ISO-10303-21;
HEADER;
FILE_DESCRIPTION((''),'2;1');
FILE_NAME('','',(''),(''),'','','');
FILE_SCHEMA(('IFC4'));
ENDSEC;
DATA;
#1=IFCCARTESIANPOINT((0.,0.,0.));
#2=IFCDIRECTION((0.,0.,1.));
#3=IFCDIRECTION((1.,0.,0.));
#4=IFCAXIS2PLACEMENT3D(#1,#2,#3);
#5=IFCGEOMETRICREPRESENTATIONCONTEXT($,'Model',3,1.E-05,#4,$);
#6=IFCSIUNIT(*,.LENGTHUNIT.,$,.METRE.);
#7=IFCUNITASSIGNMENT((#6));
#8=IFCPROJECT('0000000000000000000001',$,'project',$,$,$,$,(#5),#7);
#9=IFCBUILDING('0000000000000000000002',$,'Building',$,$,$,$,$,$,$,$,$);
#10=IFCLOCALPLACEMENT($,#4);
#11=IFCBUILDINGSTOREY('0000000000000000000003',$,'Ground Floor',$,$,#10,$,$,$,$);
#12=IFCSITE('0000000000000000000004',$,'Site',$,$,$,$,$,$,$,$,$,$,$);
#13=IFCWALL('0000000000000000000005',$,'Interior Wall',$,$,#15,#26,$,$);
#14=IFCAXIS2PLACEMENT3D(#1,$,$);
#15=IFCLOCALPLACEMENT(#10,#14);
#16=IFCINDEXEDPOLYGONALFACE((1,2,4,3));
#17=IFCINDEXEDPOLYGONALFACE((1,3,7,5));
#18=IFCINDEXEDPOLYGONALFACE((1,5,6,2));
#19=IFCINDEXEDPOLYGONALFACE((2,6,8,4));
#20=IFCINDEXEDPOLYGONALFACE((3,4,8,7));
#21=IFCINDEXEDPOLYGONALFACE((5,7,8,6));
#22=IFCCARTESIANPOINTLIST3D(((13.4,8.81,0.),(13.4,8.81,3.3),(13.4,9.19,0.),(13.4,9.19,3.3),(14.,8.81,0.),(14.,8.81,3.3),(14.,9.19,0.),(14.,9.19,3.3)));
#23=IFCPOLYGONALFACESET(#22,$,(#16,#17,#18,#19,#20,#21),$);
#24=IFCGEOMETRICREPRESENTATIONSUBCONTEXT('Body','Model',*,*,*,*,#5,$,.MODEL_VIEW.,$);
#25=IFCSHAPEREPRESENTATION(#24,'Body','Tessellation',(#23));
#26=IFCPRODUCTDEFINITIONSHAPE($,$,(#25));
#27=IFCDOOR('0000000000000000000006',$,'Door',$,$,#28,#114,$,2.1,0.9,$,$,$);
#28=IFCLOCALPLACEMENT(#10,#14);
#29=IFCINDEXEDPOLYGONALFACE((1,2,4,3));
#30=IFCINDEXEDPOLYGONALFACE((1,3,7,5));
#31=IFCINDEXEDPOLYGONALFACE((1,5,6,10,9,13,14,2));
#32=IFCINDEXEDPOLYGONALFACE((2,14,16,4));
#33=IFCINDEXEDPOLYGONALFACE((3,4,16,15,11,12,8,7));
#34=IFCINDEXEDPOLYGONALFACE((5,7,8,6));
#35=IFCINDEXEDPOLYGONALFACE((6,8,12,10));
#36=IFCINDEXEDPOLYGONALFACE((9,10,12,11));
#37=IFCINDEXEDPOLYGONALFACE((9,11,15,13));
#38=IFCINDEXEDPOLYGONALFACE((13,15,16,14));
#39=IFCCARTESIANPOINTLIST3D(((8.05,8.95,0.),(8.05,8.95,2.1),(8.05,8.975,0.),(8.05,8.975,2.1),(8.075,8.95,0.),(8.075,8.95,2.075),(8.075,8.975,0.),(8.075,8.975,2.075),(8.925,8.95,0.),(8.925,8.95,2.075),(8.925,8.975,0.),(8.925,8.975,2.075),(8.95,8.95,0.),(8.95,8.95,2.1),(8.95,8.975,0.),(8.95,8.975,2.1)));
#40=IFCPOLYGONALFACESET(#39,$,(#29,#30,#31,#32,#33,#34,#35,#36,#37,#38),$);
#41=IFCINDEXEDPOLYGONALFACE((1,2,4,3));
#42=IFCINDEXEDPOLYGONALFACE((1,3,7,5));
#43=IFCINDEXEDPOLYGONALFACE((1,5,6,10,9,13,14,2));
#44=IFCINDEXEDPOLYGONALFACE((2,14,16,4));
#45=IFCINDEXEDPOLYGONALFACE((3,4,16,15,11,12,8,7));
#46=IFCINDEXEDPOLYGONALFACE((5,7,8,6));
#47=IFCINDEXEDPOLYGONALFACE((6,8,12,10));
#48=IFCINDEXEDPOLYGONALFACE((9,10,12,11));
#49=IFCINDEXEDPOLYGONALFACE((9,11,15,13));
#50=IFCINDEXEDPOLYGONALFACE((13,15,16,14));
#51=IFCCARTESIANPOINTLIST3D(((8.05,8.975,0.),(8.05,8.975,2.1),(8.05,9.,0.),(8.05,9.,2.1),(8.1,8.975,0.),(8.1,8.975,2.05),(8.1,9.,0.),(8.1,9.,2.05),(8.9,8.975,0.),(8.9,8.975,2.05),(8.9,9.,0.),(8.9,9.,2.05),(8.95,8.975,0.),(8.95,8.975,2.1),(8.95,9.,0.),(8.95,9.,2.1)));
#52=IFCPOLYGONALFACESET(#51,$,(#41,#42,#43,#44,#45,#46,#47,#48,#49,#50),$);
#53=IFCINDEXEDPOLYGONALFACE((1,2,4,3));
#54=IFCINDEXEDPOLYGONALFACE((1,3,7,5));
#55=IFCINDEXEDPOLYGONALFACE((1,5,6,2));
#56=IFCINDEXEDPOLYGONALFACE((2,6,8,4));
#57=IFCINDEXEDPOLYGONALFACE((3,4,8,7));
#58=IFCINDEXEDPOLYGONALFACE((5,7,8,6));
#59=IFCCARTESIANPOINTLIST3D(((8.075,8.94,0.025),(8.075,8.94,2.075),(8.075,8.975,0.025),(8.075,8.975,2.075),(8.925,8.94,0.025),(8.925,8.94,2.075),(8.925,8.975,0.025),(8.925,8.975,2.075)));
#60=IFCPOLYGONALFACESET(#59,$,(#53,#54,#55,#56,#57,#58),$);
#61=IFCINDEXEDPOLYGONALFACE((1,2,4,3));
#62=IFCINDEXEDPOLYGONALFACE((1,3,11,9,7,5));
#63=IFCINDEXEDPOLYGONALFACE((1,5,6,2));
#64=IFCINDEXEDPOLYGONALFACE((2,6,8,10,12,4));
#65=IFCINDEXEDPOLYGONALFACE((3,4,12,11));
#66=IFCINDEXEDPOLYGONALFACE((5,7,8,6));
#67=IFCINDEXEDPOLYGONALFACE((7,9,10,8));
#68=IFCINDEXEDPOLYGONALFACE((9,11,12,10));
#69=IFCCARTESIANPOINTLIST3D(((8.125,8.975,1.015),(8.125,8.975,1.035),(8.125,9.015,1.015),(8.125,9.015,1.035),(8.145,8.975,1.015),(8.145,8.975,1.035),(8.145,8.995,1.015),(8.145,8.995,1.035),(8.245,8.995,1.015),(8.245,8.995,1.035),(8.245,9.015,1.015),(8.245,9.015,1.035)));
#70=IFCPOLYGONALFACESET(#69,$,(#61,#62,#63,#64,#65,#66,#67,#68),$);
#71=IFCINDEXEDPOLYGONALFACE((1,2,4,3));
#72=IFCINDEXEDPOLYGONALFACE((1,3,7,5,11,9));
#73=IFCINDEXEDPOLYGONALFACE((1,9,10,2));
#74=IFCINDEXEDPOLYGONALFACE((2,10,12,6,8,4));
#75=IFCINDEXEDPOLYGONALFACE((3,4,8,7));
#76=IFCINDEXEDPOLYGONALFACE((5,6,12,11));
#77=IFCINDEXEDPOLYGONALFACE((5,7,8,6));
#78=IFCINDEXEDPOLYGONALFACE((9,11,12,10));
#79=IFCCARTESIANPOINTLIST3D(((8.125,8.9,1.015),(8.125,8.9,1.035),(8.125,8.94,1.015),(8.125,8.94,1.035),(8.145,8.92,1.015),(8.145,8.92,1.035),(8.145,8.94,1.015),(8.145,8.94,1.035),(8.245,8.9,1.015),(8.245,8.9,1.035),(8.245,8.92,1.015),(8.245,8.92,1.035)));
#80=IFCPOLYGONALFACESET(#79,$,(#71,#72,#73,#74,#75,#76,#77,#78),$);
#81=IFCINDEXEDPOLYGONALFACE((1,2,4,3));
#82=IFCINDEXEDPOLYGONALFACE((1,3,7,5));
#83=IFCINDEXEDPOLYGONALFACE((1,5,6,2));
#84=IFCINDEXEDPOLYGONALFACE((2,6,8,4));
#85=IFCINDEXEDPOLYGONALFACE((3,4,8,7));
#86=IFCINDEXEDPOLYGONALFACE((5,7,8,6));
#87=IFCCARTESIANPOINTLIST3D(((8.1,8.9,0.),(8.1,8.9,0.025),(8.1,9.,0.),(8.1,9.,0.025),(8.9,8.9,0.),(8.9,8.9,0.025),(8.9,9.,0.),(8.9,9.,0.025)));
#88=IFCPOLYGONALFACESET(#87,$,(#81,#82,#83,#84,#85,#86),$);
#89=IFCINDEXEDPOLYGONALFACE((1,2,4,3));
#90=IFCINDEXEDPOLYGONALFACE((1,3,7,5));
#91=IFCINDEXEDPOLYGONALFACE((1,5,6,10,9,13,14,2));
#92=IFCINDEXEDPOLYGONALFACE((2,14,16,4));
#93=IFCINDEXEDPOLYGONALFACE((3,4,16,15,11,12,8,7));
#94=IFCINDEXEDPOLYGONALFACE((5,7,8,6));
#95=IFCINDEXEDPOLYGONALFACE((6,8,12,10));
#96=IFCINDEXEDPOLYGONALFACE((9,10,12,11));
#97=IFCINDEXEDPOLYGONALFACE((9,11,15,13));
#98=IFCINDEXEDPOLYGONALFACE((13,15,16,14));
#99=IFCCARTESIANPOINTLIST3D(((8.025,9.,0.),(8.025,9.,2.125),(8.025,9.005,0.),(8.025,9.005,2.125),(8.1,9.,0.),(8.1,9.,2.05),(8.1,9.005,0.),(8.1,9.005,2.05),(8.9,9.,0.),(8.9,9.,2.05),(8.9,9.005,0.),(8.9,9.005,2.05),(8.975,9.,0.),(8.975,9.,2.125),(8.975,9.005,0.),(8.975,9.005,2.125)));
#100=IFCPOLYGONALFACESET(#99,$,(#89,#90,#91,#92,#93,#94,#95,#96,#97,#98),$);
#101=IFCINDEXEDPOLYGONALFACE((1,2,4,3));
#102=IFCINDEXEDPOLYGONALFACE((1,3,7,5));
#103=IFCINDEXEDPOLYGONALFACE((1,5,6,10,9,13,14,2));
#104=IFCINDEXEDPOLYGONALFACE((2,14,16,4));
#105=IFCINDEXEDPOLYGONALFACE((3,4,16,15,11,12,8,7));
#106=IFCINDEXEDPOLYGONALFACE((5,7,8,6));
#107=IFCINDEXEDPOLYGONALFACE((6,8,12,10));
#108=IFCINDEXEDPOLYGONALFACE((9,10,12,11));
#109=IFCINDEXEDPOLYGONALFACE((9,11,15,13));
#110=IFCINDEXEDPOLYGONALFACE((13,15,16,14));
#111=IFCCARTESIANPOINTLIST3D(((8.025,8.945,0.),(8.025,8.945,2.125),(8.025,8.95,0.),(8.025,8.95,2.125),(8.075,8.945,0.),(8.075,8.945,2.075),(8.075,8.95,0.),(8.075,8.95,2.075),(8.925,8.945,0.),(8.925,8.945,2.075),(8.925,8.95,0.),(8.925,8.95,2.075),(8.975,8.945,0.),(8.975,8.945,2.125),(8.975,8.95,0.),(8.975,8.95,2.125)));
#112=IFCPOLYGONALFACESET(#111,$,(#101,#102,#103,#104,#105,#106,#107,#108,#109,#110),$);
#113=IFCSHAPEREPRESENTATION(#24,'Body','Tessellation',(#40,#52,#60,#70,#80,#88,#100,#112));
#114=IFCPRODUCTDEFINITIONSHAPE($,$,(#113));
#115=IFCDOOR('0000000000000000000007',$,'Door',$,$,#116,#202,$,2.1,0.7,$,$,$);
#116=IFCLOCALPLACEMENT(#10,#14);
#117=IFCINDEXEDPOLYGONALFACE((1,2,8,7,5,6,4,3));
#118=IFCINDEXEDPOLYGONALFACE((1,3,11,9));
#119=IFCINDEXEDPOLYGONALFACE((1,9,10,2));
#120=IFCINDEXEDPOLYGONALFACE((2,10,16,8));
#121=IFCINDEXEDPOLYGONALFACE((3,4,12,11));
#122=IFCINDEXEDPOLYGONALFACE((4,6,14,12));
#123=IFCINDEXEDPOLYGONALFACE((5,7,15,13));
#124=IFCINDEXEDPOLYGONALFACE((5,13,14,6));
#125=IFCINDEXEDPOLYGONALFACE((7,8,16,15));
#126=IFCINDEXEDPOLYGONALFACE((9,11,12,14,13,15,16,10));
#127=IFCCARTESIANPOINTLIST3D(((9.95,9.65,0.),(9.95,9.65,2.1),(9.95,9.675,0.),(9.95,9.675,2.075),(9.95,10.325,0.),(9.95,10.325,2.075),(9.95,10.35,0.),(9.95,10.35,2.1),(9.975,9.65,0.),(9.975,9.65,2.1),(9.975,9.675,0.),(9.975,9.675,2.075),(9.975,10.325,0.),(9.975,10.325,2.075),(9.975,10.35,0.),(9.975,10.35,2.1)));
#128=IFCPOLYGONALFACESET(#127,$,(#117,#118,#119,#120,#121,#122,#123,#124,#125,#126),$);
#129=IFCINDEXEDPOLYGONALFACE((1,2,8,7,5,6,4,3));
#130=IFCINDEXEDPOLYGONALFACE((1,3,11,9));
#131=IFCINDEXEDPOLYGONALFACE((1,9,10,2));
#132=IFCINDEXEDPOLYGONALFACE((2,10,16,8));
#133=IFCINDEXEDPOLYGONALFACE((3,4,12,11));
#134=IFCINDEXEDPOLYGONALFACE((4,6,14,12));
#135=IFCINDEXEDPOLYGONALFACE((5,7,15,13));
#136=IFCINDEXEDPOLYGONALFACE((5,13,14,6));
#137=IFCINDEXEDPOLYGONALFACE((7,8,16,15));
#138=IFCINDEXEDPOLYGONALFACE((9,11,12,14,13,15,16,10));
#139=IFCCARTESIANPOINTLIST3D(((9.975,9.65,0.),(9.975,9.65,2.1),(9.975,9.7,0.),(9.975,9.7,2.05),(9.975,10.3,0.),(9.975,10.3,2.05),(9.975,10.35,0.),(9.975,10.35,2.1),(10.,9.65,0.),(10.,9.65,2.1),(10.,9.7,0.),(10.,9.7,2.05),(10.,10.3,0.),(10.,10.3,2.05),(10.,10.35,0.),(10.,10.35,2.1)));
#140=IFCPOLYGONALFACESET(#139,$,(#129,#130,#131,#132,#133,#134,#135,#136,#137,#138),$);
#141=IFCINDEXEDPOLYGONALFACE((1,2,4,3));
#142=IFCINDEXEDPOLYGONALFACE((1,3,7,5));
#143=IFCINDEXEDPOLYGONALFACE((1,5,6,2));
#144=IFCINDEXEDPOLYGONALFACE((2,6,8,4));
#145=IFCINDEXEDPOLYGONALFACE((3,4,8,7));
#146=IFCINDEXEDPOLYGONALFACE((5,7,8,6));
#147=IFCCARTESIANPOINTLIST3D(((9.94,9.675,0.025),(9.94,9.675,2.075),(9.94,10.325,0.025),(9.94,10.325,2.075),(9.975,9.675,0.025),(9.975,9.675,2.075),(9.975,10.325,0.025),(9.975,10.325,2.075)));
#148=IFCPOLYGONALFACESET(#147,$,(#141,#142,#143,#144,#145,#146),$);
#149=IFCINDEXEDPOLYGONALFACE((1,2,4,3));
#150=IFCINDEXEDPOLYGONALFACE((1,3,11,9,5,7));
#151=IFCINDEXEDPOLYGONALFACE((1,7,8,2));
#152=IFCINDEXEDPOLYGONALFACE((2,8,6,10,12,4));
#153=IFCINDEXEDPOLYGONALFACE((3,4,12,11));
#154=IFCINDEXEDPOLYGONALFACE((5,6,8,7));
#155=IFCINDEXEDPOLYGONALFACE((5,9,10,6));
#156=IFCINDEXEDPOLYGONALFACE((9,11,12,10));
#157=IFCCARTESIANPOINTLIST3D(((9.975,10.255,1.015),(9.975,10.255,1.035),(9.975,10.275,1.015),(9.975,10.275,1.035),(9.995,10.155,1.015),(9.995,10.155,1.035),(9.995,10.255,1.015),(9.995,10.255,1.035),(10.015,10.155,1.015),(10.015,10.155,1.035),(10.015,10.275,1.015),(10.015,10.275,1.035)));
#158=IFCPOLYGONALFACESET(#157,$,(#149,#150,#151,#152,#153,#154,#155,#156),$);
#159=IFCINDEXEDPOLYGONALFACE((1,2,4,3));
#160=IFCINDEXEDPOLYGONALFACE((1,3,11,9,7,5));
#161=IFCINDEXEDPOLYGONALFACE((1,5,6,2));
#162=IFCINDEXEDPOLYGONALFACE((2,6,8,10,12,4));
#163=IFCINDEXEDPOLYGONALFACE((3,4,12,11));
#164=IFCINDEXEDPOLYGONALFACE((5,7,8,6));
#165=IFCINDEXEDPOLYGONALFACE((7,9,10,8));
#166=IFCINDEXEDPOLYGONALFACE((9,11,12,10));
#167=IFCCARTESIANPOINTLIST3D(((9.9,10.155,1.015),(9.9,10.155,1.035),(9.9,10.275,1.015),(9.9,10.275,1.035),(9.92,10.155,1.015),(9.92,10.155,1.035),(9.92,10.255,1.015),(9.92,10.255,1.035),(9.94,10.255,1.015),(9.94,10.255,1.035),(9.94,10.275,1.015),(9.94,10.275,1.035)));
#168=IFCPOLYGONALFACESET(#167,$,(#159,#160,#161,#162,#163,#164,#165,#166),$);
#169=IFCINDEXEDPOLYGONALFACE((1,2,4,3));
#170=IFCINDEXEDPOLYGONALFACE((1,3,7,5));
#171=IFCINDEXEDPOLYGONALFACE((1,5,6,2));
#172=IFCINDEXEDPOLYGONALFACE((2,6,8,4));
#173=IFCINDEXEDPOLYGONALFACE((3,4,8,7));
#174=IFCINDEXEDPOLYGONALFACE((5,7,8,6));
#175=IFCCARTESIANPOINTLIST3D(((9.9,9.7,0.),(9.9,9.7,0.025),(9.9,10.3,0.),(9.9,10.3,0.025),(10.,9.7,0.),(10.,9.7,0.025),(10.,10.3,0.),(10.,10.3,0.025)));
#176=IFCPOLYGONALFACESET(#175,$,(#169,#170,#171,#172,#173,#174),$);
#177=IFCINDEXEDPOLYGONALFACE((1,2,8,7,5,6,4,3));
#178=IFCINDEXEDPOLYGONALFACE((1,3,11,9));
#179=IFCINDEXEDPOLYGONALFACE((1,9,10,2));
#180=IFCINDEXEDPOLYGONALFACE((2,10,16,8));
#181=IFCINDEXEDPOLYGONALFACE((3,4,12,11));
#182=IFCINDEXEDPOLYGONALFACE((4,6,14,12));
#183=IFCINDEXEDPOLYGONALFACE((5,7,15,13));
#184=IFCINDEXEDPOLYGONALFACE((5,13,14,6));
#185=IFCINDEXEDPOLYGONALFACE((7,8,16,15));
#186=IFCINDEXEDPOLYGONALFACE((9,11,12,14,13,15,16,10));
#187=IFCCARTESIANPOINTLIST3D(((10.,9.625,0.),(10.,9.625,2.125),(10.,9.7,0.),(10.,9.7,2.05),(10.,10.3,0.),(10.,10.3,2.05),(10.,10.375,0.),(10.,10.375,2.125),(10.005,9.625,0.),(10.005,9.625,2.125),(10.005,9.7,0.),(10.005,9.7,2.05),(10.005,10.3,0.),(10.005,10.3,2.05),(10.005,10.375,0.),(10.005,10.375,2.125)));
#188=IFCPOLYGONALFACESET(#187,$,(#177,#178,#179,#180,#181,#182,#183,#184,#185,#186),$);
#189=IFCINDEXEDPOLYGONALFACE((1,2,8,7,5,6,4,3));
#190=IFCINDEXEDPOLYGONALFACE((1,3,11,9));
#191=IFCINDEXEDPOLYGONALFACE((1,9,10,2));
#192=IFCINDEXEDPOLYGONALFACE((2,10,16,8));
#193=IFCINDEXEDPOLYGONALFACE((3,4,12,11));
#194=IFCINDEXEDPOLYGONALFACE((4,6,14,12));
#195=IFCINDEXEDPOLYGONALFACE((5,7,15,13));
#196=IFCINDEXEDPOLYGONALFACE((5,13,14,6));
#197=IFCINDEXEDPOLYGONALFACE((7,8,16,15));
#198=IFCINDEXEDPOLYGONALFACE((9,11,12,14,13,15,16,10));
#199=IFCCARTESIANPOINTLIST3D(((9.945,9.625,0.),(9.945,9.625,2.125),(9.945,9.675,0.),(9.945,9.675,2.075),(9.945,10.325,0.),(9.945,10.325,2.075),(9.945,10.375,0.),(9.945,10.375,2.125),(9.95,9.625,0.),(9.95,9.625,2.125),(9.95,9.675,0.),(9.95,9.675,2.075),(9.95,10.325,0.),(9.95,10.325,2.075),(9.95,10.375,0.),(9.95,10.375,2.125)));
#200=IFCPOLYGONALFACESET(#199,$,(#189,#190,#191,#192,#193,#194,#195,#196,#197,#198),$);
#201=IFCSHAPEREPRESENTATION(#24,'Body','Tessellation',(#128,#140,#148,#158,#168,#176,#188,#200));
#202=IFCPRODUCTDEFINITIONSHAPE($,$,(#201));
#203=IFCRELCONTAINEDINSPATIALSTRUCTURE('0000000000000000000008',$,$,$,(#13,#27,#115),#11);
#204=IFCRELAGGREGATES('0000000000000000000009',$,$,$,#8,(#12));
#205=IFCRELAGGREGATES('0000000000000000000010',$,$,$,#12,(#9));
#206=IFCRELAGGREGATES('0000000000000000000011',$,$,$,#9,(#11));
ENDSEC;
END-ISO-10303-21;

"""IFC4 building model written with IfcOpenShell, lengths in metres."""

from ifc_helpers import new_model, si_unit, frame, origin_with_axes, place, context, subcontext, project, spatial, line, indexed_curve, outline, extrude, element, save


model = new_model("IFC4")

# Units and contexts
model_context = context("Model", 3, precision=1e-05, world=origin_with_axes())
body_context = subcontext(model_context, "Body", "Model", "MODEL_VIEW")
ifc_project = project(units=[si_unit("LENGTHUNIT", "METRE")], contexts=[model_context])

# Site, building, storey
site = spatial("IfcSite", under=ifc_project, Name="Site")
building = spatial("IfcBuilding", under=site, Name="Building")
storey_placement = place(None, origin_with_axes())
storey = spatial("IfcBuildingStorey", under=building, at=storey_placement, Name="Ground Floor")

# Wall
for number, where, z_axis, x_axis, name in (
    (1, (13.4, 9.0, 0.0), (0.0, 0.0, 1.0), (1.0, 0.0, 0.0), "Interior Wall"),
):
    element("IfcWall", number, at=place(storey_placement, frame(where, z_axis=z_axis, x_axis=x_axis)), inside=storey, Name=name, context=body_context, shape_type="SweptSolid", body=[
        extrude(outline(indexed_curve([(0.0, 0.0), (0.0, 0.38), (0.6, 0.38), (0.6, 0.0), (0.0, 0.0)], self_intersect=False)), frame((0.0, -0.19, 0.0), z_axis=(0.0, 0.0, 1.0), x_axis=(1.0, 0.0, 0.0)), (0.0, 0.0, 1.0), 3.3),
    ])

# Doors
door_1_placement = place(storey_placement, frame((8.95, 9.0, 0.0), z_axis=(0.0, 0.0, 1.0), x_axis=(-1.0, 0.0, 0.0)))
element("IfcDoor", 2, at=door_1_placement, inside=storey, Name="Door", OverallHeight=2.1, OverallWidth=0.9, context=body_context, shape_type="SweptSolid", body=[
    extrude(outline(indexed_curve([(0.0, 0.0), (0.0, 2.1), (0.9, 2.1), (0.9, 0.0), (0.875, 0.0), (0.875, 2.075), (0.025, 2.075), (0.025, 0.0)], segments=[line(1, 2, 3, 4, 5, 6, 7, 8, 1)])), frame((0.0, 0.025, 0.0), z_axis=(0.0, -1.0, 0.0), x_axis=(1.0, 0.0, 0.0)), (0.0, 0.0, -1.0), 0.025),
    extrude(outline(indexed_curve([(0.0, 0.0), (0.0, 2.1), (0.9, 2.1), (0.9, 0.0), (0.85, 0.0), (0.85, 2.05), (0.05, 2.05), (0.05, 0.0)], segments=[line(1, 2, 3, 4, 5, 6, 7, 8, 1)])), frame((0.0, 0.0, 0.0), z_axis=(0.0, -1.0, 0.0), x_axis=(1.0, 0.0, 0.0)), (0.0, 0.0, -1.0), 0.025),
    extrude(outline(indexed_curve([(0.0, 0.0), (0.85, 0.0), (0.85, 0.035), (0.0, 0.035)], segments=[line(1, 2, 3, 4, 1)])), frame((0.025, 0.025, 0.025), z_axis=(0.0, 0.0, 1.0), x_axis=(1.0, 0.0, 0.0)), (0.0, 0.0, 1.0), 2.05),
    extrude(outline(indexed_curve([(0.0, 0.0), (0.0, -0.04), (-0.12, -0.04), (-0.12, -0.02), (-0.02, -0.02), (-0.02, 0.0)], segments=[line(1, 2, 3, 4, 5, 6, 1)])), frame((0.825, 0.025, 1.015), z_axis=(0.0, 0.0, 1.0), x_axis=(1.0, 0.0, 0.0)), (0.0, 0.0, 1.0), 0.02),
    extrude(outline(indexed_curve([(0.0, 0.0), (0.0, 0.04), (-0.12, 0.04), (-0.12, 0.02), (-0.02, 0.02), (-0.02, 0.0)], segments=[line(1, 2, 3, 4, 5, 6, 1)])), frame((0.825, 0.06, 1.015), z_axis=(0.0, 0.0, 1.0), x_axis=(1.0, 0.0, 0.0)), (0.0, 0.0, 1.0), 0.02),
    extrude(outline(indexed_curve([(0.0, 0.0), (0.8, 0.0), (0.8, 0.1), (0.0, 0.1)], segments=[line(1, 2, 3, 4, 1)])), frame((0.05, 0.0, 0.0), z_axis=(0.0, 0.0, 1.0), x_axis=(1.0, 0.0, 0.0)), (0.0, 0.0, 1.0), 0.025),
    extrude(outline(indexed_curve([(0.0, 0.0), (0.0, 2.125), (0.95, 2.125), (0.95, 0.0), (0.875, 0.0), (0.875, 2.05), (0.075, 2.05), (0.075, 0.0)], segments=[line(1, 2, 3, 4, 5, 6, 7, 8, 1)])), frame((-0.025, -0.005, 0.0), z_axis=(0.0, -1.0, 0.0), x_axis=(1.0, 0.0, 0.0)), (0.0, 0.0, -1.0), 0.005),
    extrude(outline(indexed_curve([(0.0, 0.0), (0.0, 2.125), (0.95, 2.125), (0.95, 0.0), (0.9, 0.0), (0.9, 2.075), (0.05, 2.075), (0.05, 0.0)], segments=[line(1, 2, 3, 4, 5, 6, 7, 8, 1)])), frame((-0.025, 0.05, 0.0), z_axis=(0.0, -1.0, 0.0), x_axis=(1.0, 0.0, 0.0)), (0.0, 0.0, -1.0), 0.005),
])
door_2_placement = place(storey_placement, frame((10.0, 9.65, 0.0), z_axis=(0.0, 0.0, 1.0), x_axis=(0.0, 1.0, 0.0)))
element("IfcDoor", 3, at=door_2_placement, inside=storey, Name="Door", OverallHeight=2.1, OverallWidth=0.7, context=body_context, shape_type="SweptSolid", body=[
    extrude(outline(indexed_curve([(0.0, 0.0), (0.0, 2.1), (0.7, 2.1), (0.7, 0.0), (0.675, 0.0), (0.675, 2.075), (0.025, 2.075), (0.025, 0.0)], segments=[line(1, 2, 3, 4, 5, 6, 7, 8, 1)])), frame((0.0, 0.025, 0.0), z_axis=(0.0, -1.0, 0.0), x_axis=(1.0, 0.0, 0.0)), (0.0, 0.0, -1.0), 0.025),
    extrude(outline(indexed_curve([(0.0, 0.0), (0.0, 2.1), (0.7, 2.1), (0.7, 0.0), (0.65, 0.0), (0.65, 2.05), (0.05, 2.05), (0.05, 0.0)], segments=[line(1, 2, 3, 4, 5, 6, 7, 8, 1)])), frame((0.0, 0.0, 0.0), z_axis=(0.0, -1.0, 0.0), x_axis=(1.0, 0.0, 0.0)), (0.0, 0.0, -1.0), 0.025),
    extrude(outline(indexed_curve([(0.0, 0.0), (0.65, 0.0), (0.65, 0.035), (0.0, 0.035)], segments=[line(1, 2, 3, 4, 1)])), frame((0.025, 0.025, 0.025), z_axis=(0.0, 0.0, 1.0), x_axis=(1.0, 0.0, 0.0)), (0.0, 0.0, 1.0), 2.05),
    extrude(outline(indexed_curve([(0.0, 0.0), (0.0, -0.04), (-0.12, -0.04), (-0.12, -0.02), (-0.02, -0.02), (-0.02, 0.0)], segments=[line(1, 2, 3, 4, 5, 6, 1)])), frame((0.625, 0.025, 1.015), z_axis=(0.0, 0.0, 1.0), x_axis=(1.0, 0.0, 0.0)), (0.0, 0.0, 1.0), 0.02),
    extrude(outline(indexed_curve([(0.0, 0.0), (0.0, 0.04), (-0.12, 0.04), (-0.12, 0.02), (-0.02, 0.02), (-0.02, 0.0)], segments=[line(1, 2, 3, 4, 5, 6, 1)])), frame((0.625, 0.06, 1.015), z_axis=(0.0, 0.0, 1.0), x_axis=(1.0, 0.0, 0.0)), (0.0, 0.0, 1.0), 0.02),
    extrude(outline(indexed_curve([(0.0, 0.0), (0.6, 0.0), (0.6, 0.1), (0.0, 0.1)], segments=[line(1, 2, 3, 4, 1)])), frame((0.05, 0.0, 0.0), z_axis=(0.0, 0.0, 1.0), x_axis=(1.0, 0.0, 0.0)), (0.0, 0.0, 1.0), 0.025),
    extrude(outline(indexed_curve([(0.0, 0.0), (0.0, 2.125), (0.75, 2.125), (0.75, 0.0), (0.675, 0.0), (0.675, 2.05), (0.075, 2.05), (0.075, 0.0)], segments=[line(1, 2, 3, 4, 5, 6, 7, 8, 1)])), frame((-0.025, -0.005, 0.0), z_axis=(0.0, -1.0, 0.0), x_axis=(1.0, 0.0, 0.0)), (0.0, 0.0, -1.0), 0.005),
    extrude(outline(indexed_curve([(0.0, 0.0), (0.0, 2.125), (0.75, 2.125), (0.75, 0.0), (0.7, 0.0), (0.7, 2.075), (0.05, 2.075), (0.05, 0.0)], segments=[line(1, 2, 3, 4, 5, 6, 7, 8, 1)])), frame((-0.025, 0.05, 0.0), z_axis=(0.0, -1.0, 0.0), x_axis=(1.0, 0.0, 0.0)), (0.0, 0.0, -1.0), 0.005),
])

save(model, "model.ifc")
